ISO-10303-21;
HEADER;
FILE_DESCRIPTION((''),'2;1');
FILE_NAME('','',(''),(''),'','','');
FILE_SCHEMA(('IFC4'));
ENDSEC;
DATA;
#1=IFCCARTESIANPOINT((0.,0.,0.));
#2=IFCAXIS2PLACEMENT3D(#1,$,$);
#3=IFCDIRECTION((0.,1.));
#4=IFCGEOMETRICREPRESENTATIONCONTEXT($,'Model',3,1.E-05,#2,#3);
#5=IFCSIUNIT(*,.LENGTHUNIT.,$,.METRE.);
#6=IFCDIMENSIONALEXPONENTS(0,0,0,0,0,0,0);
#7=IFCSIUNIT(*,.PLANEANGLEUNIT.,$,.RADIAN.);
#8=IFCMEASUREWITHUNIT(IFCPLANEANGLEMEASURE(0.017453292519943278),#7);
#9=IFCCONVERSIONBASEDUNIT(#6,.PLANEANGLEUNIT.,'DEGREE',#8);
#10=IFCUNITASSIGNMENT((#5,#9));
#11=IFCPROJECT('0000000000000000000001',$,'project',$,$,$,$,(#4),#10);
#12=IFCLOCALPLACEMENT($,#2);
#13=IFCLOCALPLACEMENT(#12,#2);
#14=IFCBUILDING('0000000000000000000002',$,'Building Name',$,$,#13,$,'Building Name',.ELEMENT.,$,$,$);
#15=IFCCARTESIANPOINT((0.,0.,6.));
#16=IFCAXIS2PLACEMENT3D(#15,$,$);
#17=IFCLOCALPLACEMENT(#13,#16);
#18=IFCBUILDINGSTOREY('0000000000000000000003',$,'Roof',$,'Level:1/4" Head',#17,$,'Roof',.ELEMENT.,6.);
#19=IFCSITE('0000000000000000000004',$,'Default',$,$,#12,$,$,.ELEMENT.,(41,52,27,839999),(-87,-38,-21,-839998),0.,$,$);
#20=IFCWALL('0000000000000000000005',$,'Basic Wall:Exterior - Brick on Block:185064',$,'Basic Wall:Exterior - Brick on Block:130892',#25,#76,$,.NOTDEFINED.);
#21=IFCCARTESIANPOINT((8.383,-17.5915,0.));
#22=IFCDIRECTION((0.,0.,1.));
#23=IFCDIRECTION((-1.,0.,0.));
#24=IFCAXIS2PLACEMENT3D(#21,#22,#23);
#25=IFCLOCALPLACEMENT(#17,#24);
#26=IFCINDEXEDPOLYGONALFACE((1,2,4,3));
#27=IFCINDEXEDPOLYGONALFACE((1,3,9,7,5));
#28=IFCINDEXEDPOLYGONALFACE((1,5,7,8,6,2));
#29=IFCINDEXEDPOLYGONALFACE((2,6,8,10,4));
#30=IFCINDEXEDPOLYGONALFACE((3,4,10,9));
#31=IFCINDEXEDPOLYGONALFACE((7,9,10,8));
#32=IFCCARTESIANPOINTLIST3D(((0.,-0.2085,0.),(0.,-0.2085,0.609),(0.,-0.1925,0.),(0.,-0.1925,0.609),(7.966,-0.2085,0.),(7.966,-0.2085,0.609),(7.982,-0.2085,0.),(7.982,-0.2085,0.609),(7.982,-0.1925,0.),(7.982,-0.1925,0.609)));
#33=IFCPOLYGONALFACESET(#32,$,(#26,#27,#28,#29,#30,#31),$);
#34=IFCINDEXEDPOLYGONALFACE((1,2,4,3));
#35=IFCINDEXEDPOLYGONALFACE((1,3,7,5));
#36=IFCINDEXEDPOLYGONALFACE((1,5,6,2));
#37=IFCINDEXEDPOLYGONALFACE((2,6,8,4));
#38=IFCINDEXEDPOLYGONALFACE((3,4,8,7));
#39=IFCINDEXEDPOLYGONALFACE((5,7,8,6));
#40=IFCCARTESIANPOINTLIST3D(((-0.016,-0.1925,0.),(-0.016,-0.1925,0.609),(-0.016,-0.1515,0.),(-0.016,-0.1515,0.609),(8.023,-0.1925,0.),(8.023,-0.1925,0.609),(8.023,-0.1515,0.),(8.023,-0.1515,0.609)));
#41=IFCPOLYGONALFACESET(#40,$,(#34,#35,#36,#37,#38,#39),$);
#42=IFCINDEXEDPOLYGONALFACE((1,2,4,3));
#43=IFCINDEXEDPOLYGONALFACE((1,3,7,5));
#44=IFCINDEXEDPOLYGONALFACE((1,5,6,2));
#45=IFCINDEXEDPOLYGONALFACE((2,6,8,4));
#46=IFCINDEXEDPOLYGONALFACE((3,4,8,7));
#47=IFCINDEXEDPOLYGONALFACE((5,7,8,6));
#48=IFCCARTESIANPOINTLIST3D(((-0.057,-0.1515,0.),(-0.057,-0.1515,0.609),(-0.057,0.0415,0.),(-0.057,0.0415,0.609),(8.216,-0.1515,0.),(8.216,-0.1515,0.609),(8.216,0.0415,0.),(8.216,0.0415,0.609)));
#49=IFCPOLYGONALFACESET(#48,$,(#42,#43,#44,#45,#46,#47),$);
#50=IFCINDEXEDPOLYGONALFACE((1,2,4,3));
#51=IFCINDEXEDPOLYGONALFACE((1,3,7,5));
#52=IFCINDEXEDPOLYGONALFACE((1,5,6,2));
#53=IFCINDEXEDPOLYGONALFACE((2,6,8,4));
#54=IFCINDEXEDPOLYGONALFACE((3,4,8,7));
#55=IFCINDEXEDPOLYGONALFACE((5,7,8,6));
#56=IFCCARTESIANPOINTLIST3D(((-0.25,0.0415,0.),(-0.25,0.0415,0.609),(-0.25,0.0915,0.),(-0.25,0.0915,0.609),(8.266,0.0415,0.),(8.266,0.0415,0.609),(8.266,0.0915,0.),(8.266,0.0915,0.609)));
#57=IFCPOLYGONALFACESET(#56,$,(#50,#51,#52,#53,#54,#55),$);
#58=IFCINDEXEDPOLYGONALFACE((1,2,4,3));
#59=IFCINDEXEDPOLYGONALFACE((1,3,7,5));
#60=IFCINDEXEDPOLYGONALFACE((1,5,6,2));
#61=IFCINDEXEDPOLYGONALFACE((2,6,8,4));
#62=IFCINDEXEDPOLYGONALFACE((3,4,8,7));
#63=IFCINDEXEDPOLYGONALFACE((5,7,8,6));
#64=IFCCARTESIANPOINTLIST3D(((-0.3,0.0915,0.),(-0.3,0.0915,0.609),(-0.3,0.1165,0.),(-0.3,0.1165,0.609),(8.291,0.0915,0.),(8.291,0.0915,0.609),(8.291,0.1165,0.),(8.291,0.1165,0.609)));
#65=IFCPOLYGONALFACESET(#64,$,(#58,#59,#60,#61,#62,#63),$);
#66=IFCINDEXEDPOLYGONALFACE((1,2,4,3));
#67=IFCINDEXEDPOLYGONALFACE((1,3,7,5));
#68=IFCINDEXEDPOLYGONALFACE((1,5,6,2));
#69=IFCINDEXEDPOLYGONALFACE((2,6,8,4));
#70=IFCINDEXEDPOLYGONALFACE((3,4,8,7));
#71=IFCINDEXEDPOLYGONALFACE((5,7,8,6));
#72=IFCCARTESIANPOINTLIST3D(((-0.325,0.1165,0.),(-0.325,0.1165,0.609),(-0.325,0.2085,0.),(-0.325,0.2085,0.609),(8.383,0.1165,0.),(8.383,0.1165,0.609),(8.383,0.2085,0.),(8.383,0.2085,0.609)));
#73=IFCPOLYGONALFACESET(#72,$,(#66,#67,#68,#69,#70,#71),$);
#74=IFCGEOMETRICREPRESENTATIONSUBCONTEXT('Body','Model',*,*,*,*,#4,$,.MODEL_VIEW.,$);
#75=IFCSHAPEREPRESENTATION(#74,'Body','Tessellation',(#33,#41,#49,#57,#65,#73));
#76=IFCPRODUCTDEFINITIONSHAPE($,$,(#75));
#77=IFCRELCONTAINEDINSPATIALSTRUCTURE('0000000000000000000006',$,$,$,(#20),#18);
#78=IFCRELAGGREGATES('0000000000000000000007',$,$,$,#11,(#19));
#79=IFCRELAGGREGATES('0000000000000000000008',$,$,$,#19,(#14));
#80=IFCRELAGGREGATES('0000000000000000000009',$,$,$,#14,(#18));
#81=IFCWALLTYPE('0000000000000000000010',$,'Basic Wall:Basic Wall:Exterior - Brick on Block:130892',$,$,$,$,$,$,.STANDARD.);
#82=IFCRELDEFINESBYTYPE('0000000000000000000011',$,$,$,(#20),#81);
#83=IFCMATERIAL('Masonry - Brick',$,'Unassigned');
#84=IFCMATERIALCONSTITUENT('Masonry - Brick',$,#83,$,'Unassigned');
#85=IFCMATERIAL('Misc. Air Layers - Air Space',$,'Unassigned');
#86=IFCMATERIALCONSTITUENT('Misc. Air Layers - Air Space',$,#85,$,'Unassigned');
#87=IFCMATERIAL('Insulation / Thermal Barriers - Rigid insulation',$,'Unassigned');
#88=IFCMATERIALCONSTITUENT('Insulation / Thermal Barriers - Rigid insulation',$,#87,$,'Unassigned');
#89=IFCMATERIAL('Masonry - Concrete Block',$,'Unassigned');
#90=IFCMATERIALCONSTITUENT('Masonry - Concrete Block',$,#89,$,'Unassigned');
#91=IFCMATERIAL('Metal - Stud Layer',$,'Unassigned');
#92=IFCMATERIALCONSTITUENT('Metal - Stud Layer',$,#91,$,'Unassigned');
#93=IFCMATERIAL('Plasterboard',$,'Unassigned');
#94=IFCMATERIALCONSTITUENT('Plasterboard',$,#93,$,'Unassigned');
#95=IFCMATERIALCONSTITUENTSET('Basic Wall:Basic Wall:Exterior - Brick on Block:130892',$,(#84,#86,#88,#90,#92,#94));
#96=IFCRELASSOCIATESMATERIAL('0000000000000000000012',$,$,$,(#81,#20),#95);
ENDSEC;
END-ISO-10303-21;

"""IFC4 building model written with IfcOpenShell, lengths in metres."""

from ifc_helpers import new_model, entity, si_unit, converted_unit, direction, frame, origin, place, context, subcontext, project, spatial, indexed_curve, outline, extrude, material, constituent, constituent_set, type_object, element, save


model = new_model("IFC4")

# Units and contexts
model_context = context("Model", 3, precision=1e-05, world=origin(), true_north=direction((0.0, 1.0)))
body_context = subcontext(model_context, "Body", "Model", "MODEL_VIEW")
ifc_project = project(units=[si_unit("LENGTHUNIT", "METRE"), converted_unit("PLANEANGLEUNIT", "DEGREE", entity("IfcPlaneAngleMeasure", 0.017453292519943278), si_unit("PLANEANGLEUNIT", "RADIAN"), dimensions=[0, 0, 0, 0, 0, 0, 0])], contexts=[model_context])

# Site, building, storey
site_placement = place(None, origin())
site = spatial("IfcSite", under=ifc_project, at=site_placement, Name="Default", CompositionType="ELEMENT", RefLatitude=(41, 52, 27, 839999), RefLongitude=(-87, -38, -21, -839998), RefElevation=0.0)
building_placement = place(site_placement, origin())
building = spatial("IfcBuilding", under=site, at=building_placement, Name="Building Name", LongName="Building Name", CompositionType="ELEMENT")
storey_placement = place(building_placement, frame((0.0, 0.0, 6.0)))
storey = spatial("IfcBuildingStorey", under=building, at=storey_placement, Name="Roof", ObjectType="Level:1/4\" Head", LongName="Roof", CompositionType="ELEMENT", Elevation=6.0)

# Shared definitions
ifc_material_1 = material(Name="Insulation / Thermal Barriers - Rigid insulation", Category="Unassigned")

# Wall
ifc_material_2 = material(Name="Masonry - Brick", Category="Unassigned")
ifc_constituent_1 = constituent(ifc_material_2, Name="Masonry - Brick", Category="Unassigned")
ifc_material_3 = material(Name="Misc. Air Layers - Air Space", Category="Unassigned")
ifc_constituent_2 = constituent(ifc_material_3, Name="Misc. Air Layers - Air Space", Category="Unassigned")
ifc_constituent_3 = constituent(ifc_material_1, Name="Insulation / Thermal Barriers - Rigid insulation", Category="Unassigned")
ifc_material_4 = material(Name="Masonry - Concrete Block", Category="Unassigned")
ifc_constituent_4 = constituent(ifc_material_4, Name="Masonry - Concrete Block", Category="Unassigned")
ifc_material_5 = material(Name="Metal - Stud Layer", Category="Unassigned")
ifc_constituent_5 = constituent(ifc_material_5, Name="Metal - Stud Layer", Category="Unassigned")
ifc_material_6 = material(Name="Plasterboard", Category="Unassigned")
ifc_constituent_6 = constituent(ifc_material_6, Name="Plasterboard", Category="Unassigned")
ifc_constituent_set_1 = constituent_set(constituents=[ifc_constituent_1, ifc_constituent_2, ifc_constituent_3, ifc_constituent_4, ifc_constituent_5, ifc_constituent_6], Name="Basic Wall:Basic Wall:Exterior - Brick on Block:130892")
wall_type = type_object("IfcWallType", Name="Basic Wall:Basic Wall:Exterior - Brick on Block:130892", PredefinedType="STANDARD", material=ifc_constituent_set_1)
wall_1_placement = place(storey_placement, frame((8.383, -17.5915, 0.0), z_axis=(0.0, 0.0, 1.0), x_axis=(-1.0, 0.0, 0.0)))
element("IfcWall", 1, at=wall_1_placement, inside=storey, type_object=wall_type, material=ifc_constituent_set_1, Name="Basic Wall:Exterior - Brick on Block:185064", ObjectType="Basic Wall:Exterior - Brick on Block:130892", PredefinedType="NOTDEFINED", context=body_context, shape_type="SweptSolid", body=[
    extrude(outline(indexed_curve([(3.18, -0.0064), (3.196, -0.0064), (3.196, 0.0096), (-4.786, 0.0096), (-4.786, -0.0064), (3.18, -0.0064)], self_intersect=False)), frame((4.786, -0.2021, 0.0)), (0.0, 0.0, 1.0), 0.609),
    extrude(outline(indexed_curve([(-4.0195, -0.0205), (4.0195, -0.0205), (4.0195, 0.0205), (-4.0195, 0.0205), (-4.0195, -0.0205)], self_intersect=False)), frame((4.0035, -0.172, 0.0)), (0.0, 0.0, 1.0), 0.609),
    extrude(outline(indexed_curve([(-4.1365, -0.0965), (4.1365, -0.0965), (4.1365, 0.0965), (-4.1365, 0.0965), (-4.1365, -0.0965)], self_intersect=False)), frame((4.0795, -0.055, 0.0)), (0.0, 0.0, 1.0), 0.609),
    extrude(outline(indexed_curve([(-4.258, -0.025), (4.258, -0.025), (4.258, 0.025), (-4.258, 0.025), (-4.258, -0.025)], self_intersect=False)), frame((4.008, 0.0665, 0.0)), (0.0, 0.0, 1.0), 0.609),
    extrude(outline(indexed_curve([(-4.2955, -0.0125), (4.2955, -0.0125), (4.2955, 0.0125), (-4.2955, 0.0125), (-4.2955, -0.0125)], self_intersect=False)), frame((3.9955, 0.104, 0.0)), (0.0, 0.0, 1.0), 0.609),
    extrude(outline(indexed_curve([(-0.046, -4.354), (0.046, -4.354), (0.046, 4.354), (-0.046, 4.354), (-0.046, -4.354)], self_intersect=False)), frame((4.029, 0.1625, 0.0), z_axis=(0.0, 0.0, 1.0), x_axis=(0.0, -1.0, 0.0)), (0.0, 0.0, 1.0), 0.609),
])

save(model, "model.ifc")
